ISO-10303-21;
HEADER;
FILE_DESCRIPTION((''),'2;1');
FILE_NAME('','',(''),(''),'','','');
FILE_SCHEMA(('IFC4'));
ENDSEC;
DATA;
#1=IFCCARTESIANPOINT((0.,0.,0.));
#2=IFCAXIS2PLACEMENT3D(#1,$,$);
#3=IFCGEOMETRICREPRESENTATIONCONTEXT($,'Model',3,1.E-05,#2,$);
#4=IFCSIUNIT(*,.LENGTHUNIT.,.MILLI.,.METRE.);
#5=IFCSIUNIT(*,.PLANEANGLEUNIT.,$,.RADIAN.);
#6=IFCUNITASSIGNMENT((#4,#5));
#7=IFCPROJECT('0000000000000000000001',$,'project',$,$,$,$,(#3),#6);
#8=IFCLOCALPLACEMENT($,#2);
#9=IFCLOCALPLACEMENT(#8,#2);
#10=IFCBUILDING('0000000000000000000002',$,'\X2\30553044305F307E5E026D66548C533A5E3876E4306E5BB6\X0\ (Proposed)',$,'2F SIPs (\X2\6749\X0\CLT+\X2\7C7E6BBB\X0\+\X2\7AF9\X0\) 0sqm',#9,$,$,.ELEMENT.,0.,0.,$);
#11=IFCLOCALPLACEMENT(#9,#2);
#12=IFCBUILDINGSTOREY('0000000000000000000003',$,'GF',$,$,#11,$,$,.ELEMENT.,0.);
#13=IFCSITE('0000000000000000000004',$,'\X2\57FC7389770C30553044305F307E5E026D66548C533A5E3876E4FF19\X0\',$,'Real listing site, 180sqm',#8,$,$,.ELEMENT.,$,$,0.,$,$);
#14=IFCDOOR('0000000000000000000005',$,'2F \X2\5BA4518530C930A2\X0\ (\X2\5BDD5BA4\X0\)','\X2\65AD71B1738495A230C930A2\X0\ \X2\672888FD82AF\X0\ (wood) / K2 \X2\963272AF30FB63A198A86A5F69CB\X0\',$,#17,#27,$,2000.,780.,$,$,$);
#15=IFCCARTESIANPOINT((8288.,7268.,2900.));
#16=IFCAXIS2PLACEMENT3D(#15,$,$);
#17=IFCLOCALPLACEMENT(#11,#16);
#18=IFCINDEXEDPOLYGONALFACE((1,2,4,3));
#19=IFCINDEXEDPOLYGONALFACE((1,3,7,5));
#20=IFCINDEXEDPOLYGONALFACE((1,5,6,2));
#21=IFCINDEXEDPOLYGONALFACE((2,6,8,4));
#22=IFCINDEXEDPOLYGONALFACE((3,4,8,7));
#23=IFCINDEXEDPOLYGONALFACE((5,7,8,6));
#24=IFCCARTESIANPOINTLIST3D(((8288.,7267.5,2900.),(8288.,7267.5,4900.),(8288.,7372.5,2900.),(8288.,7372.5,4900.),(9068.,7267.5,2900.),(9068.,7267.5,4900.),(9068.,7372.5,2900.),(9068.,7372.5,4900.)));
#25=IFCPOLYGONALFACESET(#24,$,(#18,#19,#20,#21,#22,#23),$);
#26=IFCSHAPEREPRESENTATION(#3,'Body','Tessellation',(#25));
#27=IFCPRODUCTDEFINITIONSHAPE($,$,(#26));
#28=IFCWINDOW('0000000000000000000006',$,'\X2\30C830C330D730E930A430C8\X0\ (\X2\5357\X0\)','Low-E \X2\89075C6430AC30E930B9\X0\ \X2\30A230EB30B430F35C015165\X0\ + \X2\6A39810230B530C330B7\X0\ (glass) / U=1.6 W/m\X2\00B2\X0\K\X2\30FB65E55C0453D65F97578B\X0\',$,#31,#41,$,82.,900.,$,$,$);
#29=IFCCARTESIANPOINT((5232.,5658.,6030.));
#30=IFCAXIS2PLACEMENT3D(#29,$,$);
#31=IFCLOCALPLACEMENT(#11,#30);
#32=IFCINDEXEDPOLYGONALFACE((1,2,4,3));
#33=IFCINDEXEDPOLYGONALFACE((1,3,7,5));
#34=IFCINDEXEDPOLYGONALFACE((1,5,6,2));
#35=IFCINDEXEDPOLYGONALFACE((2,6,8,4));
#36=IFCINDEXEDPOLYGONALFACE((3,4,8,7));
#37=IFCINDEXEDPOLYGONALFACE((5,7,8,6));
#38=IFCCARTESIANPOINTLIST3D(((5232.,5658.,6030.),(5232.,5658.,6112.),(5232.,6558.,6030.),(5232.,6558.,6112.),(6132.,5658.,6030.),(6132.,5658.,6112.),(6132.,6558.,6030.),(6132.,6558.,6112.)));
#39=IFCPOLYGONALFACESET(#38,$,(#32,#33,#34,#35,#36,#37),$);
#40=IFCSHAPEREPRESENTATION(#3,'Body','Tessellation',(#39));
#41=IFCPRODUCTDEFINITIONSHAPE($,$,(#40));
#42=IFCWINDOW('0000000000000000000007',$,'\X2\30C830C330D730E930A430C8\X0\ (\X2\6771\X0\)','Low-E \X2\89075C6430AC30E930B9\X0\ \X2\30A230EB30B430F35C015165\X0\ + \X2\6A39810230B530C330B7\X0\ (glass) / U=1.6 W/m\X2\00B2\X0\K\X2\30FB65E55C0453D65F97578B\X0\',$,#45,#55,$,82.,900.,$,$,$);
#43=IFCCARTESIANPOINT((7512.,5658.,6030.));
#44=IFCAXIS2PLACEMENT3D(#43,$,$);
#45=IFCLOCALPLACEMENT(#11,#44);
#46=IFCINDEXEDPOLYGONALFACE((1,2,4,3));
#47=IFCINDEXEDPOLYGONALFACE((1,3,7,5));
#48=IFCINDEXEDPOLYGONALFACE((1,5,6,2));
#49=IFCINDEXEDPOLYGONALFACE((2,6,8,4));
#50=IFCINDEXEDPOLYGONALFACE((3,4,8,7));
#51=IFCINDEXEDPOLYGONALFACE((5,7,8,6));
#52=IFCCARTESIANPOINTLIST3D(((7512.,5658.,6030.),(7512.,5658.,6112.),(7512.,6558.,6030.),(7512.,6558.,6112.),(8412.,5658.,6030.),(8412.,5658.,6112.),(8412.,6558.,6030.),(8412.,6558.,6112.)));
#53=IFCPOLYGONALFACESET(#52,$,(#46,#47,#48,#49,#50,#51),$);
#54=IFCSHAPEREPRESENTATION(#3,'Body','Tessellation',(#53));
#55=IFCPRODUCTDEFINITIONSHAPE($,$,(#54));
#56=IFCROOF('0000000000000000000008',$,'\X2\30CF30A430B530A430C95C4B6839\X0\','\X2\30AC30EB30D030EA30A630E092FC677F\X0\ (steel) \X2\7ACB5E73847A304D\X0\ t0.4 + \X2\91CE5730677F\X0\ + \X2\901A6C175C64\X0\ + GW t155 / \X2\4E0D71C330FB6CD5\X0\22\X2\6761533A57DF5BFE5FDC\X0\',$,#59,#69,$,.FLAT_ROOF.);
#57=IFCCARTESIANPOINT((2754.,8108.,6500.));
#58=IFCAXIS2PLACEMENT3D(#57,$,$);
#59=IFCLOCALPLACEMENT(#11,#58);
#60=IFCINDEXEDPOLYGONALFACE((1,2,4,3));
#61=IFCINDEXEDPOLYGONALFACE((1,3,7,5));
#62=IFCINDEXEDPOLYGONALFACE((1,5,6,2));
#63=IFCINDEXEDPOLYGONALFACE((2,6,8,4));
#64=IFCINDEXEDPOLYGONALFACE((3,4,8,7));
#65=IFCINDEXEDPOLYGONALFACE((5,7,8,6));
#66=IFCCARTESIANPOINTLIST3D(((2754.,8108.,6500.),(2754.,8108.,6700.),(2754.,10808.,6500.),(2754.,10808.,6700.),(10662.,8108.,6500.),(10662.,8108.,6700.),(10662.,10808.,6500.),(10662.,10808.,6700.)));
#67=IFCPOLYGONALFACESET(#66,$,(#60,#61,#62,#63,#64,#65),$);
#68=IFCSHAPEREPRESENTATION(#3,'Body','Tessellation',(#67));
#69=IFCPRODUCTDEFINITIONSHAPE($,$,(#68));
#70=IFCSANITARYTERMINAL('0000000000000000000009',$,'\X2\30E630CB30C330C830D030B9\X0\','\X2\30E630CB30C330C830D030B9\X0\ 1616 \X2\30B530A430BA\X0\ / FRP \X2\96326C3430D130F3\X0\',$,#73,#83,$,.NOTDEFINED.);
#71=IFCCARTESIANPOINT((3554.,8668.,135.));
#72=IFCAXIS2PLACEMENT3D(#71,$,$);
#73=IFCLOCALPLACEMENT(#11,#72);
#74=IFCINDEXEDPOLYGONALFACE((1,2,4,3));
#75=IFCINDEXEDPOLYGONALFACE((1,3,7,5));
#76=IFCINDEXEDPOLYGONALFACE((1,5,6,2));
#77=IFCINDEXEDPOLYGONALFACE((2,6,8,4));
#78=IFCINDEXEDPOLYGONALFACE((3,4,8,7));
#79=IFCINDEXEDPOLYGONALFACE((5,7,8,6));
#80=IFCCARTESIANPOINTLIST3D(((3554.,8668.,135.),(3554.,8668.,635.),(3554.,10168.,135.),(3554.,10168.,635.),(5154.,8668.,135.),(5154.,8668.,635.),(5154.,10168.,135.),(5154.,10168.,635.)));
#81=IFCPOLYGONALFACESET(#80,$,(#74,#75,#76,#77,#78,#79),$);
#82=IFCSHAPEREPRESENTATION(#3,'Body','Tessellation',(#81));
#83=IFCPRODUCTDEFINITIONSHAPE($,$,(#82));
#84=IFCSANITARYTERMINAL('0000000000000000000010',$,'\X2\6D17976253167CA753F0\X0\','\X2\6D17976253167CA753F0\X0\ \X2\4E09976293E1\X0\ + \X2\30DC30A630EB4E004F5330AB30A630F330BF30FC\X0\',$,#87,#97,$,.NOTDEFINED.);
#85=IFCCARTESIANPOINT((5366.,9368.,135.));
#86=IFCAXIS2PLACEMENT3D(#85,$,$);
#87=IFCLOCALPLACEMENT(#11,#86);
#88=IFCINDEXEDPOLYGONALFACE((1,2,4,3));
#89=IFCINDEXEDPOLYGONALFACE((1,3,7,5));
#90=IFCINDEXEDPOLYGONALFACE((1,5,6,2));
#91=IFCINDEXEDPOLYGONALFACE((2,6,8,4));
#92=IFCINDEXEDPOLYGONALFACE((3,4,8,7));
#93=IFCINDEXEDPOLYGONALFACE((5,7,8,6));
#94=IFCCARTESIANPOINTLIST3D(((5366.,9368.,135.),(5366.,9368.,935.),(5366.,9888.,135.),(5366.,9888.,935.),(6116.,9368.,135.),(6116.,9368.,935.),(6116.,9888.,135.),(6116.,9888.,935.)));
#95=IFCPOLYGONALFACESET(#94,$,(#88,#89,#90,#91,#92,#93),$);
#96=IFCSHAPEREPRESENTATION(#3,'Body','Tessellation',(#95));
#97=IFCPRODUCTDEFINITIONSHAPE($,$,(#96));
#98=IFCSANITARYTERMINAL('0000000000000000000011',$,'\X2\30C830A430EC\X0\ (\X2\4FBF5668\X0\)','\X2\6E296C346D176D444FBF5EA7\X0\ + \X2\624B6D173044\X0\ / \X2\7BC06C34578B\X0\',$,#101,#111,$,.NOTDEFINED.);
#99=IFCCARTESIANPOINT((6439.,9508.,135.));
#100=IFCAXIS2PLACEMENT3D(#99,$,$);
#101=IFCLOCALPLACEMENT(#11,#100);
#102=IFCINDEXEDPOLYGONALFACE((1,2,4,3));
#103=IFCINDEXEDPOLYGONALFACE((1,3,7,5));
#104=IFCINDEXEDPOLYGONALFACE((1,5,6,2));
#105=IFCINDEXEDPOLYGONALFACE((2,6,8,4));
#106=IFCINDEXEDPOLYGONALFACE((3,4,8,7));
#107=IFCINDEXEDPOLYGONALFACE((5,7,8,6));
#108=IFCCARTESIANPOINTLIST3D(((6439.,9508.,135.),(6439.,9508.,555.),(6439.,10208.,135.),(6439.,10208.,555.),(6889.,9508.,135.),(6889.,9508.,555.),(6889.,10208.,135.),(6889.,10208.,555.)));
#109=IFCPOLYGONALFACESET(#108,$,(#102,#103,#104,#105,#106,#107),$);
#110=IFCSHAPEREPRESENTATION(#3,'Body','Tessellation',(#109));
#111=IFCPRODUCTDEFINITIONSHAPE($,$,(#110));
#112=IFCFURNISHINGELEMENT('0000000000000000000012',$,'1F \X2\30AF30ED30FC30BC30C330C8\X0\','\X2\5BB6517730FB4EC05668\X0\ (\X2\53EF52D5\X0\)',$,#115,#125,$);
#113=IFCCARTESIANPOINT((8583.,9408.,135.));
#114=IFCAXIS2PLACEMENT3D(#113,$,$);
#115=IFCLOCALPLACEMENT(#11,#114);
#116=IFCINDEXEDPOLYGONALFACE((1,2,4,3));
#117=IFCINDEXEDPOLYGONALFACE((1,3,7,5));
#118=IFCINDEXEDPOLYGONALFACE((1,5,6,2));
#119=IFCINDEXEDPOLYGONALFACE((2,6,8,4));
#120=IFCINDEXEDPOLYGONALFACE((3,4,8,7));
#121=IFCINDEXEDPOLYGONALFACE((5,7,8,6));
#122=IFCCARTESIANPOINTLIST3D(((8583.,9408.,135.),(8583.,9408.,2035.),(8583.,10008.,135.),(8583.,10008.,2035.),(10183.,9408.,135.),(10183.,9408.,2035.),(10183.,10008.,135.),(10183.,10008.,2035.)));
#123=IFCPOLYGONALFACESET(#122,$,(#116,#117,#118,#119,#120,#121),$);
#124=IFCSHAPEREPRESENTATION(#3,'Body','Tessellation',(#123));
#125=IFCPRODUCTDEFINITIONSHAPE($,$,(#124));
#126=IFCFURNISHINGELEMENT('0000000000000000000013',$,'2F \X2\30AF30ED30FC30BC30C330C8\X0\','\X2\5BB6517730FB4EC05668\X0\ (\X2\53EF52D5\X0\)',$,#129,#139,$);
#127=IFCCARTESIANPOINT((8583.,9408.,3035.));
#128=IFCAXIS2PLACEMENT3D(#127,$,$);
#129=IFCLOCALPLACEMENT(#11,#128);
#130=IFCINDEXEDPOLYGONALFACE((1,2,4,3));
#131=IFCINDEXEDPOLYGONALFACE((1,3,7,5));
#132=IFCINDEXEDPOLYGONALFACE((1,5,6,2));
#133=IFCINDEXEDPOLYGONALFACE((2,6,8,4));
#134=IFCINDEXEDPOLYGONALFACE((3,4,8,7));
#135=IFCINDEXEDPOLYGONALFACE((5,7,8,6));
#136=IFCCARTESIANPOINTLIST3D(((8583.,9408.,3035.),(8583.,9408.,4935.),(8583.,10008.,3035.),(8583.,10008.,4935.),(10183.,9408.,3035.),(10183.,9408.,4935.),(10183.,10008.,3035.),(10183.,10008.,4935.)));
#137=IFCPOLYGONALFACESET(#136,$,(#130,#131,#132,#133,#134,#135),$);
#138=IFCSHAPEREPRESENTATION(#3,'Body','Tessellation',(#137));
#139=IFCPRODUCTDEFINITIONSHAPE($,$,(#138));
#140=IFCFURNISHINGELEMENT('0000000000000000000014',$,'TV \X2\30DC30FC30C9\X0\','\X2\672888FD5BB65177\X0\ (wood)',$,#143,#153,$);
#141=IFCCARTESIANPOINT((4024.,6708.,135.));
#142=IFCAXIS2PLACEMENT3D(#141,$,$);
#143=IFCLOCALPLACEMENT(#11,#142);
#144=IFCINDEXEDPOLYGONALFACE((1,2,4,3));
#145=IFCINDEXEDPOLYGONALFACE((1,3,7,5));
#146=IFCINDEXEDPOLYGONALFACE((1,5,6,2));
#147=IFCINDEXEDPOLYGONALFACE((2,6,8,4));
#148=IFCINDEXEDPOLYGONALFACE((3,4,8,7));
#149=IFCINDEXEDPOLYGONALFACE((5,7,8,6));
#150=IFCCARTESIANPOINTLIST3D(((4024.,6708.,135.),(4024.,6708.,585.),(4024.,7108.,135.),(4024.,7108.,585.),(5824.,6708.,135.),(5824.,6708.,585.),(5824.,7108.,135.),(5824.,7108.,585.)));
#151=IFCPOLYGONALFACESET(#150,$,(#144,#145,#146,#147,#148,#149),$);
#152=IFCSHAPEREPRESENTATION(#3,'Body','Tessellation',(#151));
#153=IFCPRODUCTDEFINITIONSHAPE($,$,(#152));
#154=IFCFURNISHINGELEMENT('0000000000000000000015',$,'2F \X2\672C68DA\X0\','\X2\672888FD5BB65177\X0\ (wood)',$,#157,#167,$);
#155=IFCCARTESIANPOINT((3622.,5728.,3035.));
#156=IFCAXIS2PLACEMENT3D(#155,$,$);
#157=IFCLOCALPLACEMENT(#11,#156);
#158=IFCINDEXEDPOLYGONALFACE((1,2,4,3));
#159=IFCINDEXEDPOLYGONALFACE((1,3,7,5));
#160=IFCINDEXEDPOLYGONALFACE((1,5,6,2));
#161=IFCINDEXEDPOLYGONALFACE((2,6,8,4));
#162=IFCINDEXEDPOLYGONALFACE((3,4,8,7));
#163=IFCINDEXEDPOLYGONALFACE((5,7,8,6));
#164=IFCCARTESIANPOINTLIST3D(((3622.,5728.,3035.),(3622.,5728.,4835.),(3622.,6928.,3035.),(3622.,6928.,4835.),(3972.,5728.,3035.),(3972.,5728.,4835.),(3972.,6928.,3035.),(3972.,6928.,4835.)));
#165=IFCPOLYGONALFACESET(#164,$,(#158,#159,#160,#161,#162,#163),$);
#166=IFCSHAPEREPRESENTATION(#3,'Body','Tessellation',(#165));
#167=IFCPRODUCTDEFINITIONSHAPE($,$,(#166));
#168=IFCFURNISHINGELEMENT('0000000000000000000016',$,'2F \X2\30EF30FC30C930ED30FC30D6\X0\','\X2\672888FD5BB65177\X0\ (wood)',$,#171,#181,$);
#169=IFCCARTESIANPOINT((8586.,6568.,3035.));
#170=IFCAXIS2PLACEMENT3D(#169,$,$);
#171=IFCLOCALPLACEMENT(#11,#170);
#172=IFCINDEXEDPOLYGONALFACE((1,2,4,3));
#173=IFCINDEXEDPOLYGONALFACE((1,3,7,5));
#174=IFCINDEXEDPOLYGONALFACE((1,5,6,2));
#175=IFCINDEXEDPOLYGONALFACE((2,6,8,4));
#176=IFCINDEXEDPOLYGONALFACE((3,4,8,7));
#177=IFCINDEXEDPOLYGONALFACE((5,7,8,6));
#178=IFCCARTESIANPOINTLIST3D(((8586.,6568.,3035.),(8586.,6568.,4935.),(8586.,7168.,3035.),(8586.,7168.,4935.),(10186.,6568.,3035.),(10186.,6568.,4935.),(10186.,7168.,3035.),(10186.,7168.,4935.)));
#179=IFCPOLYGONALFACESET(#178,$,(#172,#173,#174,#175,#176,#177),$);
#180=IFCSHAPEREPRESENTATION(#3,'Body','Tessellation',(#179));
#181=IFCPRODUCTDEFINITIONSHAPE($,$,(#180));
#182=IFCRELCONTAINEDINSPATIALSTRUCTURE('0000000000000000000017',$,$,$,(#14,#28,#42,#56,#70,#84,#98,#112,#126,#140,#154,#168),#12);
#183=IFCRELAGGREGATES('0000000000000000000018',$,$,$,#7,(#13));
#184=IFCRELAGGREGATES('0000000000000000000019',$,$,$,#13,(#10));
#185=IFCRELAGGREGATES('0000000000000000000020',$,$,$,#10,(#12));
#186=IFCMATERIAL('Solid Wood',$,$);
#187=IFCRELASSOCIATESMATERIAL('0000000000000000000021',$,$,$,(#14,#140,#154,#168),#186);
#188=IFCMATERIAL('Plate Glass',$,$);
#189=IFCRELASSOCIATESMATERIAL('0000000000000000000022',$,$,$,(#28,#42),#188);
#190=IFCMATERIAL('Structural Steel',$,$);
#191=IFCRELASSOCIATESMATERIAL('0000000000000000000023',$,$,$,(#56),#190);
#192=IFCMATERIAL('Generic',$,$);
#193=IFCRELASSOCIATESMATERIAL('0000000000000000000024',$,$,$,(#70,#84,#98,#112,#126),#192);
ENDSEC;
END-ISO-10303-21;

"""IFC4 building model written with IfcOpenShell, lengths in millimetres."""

from ifc_helpers import new_model, si_unit, frame, frame_2d, origin, place, context, project, spatial, rectangle, extrude, material, element, save


model = new_model("IFC4")

# Units and contexts
model_context = context("Model", 3, precision=1e-05, world=origin())
ifc_project = project(units=[si_unit("LENGTHUNIT", "METRE", prefix="MILLI"), si_unit("PLANEANGLEUNIT", "RADIAN")], contexts=[model_context])

# Site, building, storey
site_placement = place(None, origin())
site = spatial("IfcSite", under=ifc_project, at=site_placement, Name="埼玉県さいたま市浦和区常盤９", ObjectType="Real listing site, 180sqm", CompositionType="ELEMENT", RefElevation=0.0)
building_placement = place(site_placement, origin())
building = spatial("IfcBuilding", under=site, at=building_placement, Name="さいたま市浦和区常盤の家 (Proposed)", ObjectType="2F SIPs (杉CLT+籾殻+竹) 0sqm", CompositionType="ELEMENT", ElevationOfRefHeight=0.0, ElevationOfTerrain=0.0)
storey_placement = place(building_placement, origin())
storey = spatial("IfcBuildingStorey", under=building, at=storey_placement, Name="GF", CompositionType="ELEMENT", Elevation=0.0)

# Shared definitions
ifc_material_1 = material(Name="Solid Wood")
ifc_material_2 = material(Name="Plate Glass")

# Door
door_1_placement = place(storey_placement, frame((8288.0, 7268.0, 2900.0)))
element("IfcDoor", 1, at=door_1_placement, inside=storey, material=ifc_material_1, Name="2F 室内ドア (寝室)", Description="断熱玄関ドア 木製芯 (wood) / K2 防犯・採風機構", OverallHeight=2000.0, OverallWidth=780.0, context=model_context, shape_type="SweptSolid", body=[
    extrude(rectangle(XDim=780.0, YDim=105.0, at=frame_2d((390.0, 52.0))), frame((8288.0, 7268.0, 2900.0)), (0.0, 0.0, 1.0), 2000.0),
])

# Windows
window_1_placement = place(storey_placement, frame((5232.0, 5658.0, 6030.0)))
element("IfcWindow", 2, at=window_1_placement, inside=storey, material=ifc_material_2, Name="トップライト (南)", Description="Low-E 複層ガラス アルゴン封入 + 樹脂サッシ (glass) / U=1.6 W/m²K・日射取得型", OverallHeight=82.0, OverallWidth=900.0, context=model_context, shape_type="SweptSolid", body=[
    extrude(rectangle(XDim=900.0, YDim=900.0, at=frame_2d((450.0, 450.0))), frame((5232.0, 5658.0, 6030.0)), (0.0, 0.0, 1.0), 82.0),
])
window_2_placement = place(storey_placement, frame((7512.0, 5658.0, 6030.0)))
element("IfcWindow", 3, at=window_2_placement, inside=storey, material=ifc_material_2, Name="トップライト (東)", Description="Low-E 複層ガラス アルゴン封入 + 樹脂サッシ (glass) / U=1.6 W/m²K・日射取得型", OverallHeight=82.0, OverallWidth=900.0, context=model_context, shape_type="SweptSolid", body=[
    extrude(rectangle(XDim=900.0, YDim=900.0, at=frame_2d((450.0, 450.0))), frame((7512.0, 5658.0, 6030.0)), (0.0, 0.0, 1.0), 82.0),
])

# Roof
ifc_material_3 = material(Name="Structural Steel")
roof_placement = place(storey_placement, frame((2754.0, 8108.0, 6500.0)))
element("IfcRoof", 4, at=roof_placement, inside=storey, material=ifc_material_3, Name="ハイサイド屋根", Description="ガルバリウム鋼板 (steel) 立平葺き t0.4 + 野地板 + 通気層 + GW t155 / 不燃・法22条区域対応", PredefinedType="FLAT_ROOF", context=model_context, shape_type="SweptSolid", body=[
    extrude(rectangle(XDim=7908.0, YDim=2700.0, at=frame_2d((3954.0, 1350.0))), frame((2754.0, 8108.0, 6500.0)), (0.0, 0.0, 1.0), 200.0),
])

# Sanitary terminals
ifc_material_4 = material(Name="Generic")
sanitary_terminal_1_placement = place(storey_placement, frame((3554.0, 8668.0, 135.0)))
element("IfcSanitaryTerminal", 5, at=sanitary_terminal_1_placement, inside=storey, material=ifc_material_4, Name="ユニットバス", Description="ユニットバス 1616 サイズ / FRP 防水パン", PredefinedType="NOTDEFINED", context=model_context, shape_type="SweptSolid", body=[
    extrude(rectangle(XDim=1600.0, YDim=1500.0, at=frame_2d((800.0, 750.0))), frame((3554.0, 8668.0, 135.0)), (0.0, 0.0, 1.0), 500.0),
])
sanitary_terminal_2_placement = place(storey_placement, frame((5366.0, 9368.0, 135.0)))
element("IfcSanitaryTerminal", 6, at=sanitary_terminal_2_placement, inside=storey, material=ifc_material_4, Name="洗面化粧台", Description="洗面化粧台 三面鏡 + ボウル一体カウンター", PredefinedType="NOTDEFINED", context=model_context, shape_type="SweptSolid", body=[
    extrude(rectangle(XDim=750.0, YDim=520.0, at=frame_2d((375.0, 260.0))), frame((5366.0, 9368.0, 135.0)), (0.0, 0.0, 1.0), 800.0),
])
sanitary_terminal_3_placement = place(storey_placement, frame((6439.0, 9508.0, 135.0)))
element("IfcSanitaryTerminal", 7, at=sanitary_terminal_3_placement, inside=storey, material=ifc_material_4, Name="トイレ (便器)", Description="温水洗浄便座 + 手洗い / 節水型", PredefinedType="NOTDEFINED", context=model_context, shape_type="SweptSolid", body=[
    extrude(rectangle(XDim=450.0, YDim=700.0, at=frame_2d((225.0, 350.0))), frame((6439.0, 9508.0, 135.0)), (0.0, 0.0, 1.0), 420.0),
])

# Furnishing elements
furnishing_1_placement = place(storey_placement, frame((8583.0, 9408.0, 135.0)))
element("IfcFurnishingElement", 8, at=furnishing_1_placement, inside=storey, material=ifc_material_4, Name="1F クローゼット", Description="家具・什器 (可動)", context=model_context, shape_type="SweptSolid", body=[
    extrude(rectangle(XDim=1600.0, YDim=600.0, at=frame_2d((800.0, 300.0))), frame((8583.0, 9408.0, 135.0)), (0.0, 0.0, 1.0), 1900.0),
])
furnishing_2_placement = place(storey_placement, frame((8583.0, 9408.0, 3035.0)))
element("IfcFurnishingElement", 9, at=furnishing_2_placement, inside=storey, material=ifc_material_4, Name="2F クローゼット", Description="家具・什器 (可動)", context=model_context, shape_type="SweptSolid", body=[
    extrude(rectangle(XDim=1600.0, YDim=600.0, at=frame_2d((800.0, 300.0))), frame((8583.0, 9408.0, 3035.0)), (0.0, 0.0, 1.0), 1900.0),
])
furnishing_3_placement = place(storey_placement, frame((4024.0, 6708.0, 135.0)))
element("IfcFurnishingElement", 10, at=furnishing_3_placement, inside=storey, material=ifc_material_1, Name="TV ボード", Description="木製家具 (wood)", context=model_context, shape_type="SweptSolid", body=[
    extrude(rectangle(XDim=1800.0, YDim=400.0, at=frame_2d((900.0, 200.0))), frame((4024.0, 6708.0, 135.0)), (0.0, 0.0, 1.0), 450.0),
])
furnishing_4_placement = place(storey_placement, frame((3622.0, 5728.0, 3035.0)))
element("IfcFurnishingElement", 11, at=furnishing_4_placement, inside=storey, material=ifc_material_1, Name="2F 本棚", Description="木製家具 (wood)", context=model_context, shape_type="SweptSolid", body=[
    extrude(rectangle(XDim=350.0, YDim=1200.0, at=frame_2d((175.0, 600.0))), frame((3622.0, 5728.0, 3035.0)), (0.0, 0.0, 1.0), 1800.0),
])
furnishing_5_placement = place(storey_placement, frame((8586.0, 6568.0, 3035.0)))
element("IfcFurnishingElement", 12, at=furnishing_5_placement, inside=storey, material=ifc_material_1, Name="2F ワードローブ", Description="木製家具 (wood)", context=model_context, shape_type="SweptSolid", body=[
    extrude(rectangle(XDim=1600.0, YDim=600.0, at=frame_2d((800.0, 300.0))), frame((8586.0, 6568.0, 3035.0)), (0.0, 0.0, 1.0), 1900.0),
])

save(model, "model.ifc")
